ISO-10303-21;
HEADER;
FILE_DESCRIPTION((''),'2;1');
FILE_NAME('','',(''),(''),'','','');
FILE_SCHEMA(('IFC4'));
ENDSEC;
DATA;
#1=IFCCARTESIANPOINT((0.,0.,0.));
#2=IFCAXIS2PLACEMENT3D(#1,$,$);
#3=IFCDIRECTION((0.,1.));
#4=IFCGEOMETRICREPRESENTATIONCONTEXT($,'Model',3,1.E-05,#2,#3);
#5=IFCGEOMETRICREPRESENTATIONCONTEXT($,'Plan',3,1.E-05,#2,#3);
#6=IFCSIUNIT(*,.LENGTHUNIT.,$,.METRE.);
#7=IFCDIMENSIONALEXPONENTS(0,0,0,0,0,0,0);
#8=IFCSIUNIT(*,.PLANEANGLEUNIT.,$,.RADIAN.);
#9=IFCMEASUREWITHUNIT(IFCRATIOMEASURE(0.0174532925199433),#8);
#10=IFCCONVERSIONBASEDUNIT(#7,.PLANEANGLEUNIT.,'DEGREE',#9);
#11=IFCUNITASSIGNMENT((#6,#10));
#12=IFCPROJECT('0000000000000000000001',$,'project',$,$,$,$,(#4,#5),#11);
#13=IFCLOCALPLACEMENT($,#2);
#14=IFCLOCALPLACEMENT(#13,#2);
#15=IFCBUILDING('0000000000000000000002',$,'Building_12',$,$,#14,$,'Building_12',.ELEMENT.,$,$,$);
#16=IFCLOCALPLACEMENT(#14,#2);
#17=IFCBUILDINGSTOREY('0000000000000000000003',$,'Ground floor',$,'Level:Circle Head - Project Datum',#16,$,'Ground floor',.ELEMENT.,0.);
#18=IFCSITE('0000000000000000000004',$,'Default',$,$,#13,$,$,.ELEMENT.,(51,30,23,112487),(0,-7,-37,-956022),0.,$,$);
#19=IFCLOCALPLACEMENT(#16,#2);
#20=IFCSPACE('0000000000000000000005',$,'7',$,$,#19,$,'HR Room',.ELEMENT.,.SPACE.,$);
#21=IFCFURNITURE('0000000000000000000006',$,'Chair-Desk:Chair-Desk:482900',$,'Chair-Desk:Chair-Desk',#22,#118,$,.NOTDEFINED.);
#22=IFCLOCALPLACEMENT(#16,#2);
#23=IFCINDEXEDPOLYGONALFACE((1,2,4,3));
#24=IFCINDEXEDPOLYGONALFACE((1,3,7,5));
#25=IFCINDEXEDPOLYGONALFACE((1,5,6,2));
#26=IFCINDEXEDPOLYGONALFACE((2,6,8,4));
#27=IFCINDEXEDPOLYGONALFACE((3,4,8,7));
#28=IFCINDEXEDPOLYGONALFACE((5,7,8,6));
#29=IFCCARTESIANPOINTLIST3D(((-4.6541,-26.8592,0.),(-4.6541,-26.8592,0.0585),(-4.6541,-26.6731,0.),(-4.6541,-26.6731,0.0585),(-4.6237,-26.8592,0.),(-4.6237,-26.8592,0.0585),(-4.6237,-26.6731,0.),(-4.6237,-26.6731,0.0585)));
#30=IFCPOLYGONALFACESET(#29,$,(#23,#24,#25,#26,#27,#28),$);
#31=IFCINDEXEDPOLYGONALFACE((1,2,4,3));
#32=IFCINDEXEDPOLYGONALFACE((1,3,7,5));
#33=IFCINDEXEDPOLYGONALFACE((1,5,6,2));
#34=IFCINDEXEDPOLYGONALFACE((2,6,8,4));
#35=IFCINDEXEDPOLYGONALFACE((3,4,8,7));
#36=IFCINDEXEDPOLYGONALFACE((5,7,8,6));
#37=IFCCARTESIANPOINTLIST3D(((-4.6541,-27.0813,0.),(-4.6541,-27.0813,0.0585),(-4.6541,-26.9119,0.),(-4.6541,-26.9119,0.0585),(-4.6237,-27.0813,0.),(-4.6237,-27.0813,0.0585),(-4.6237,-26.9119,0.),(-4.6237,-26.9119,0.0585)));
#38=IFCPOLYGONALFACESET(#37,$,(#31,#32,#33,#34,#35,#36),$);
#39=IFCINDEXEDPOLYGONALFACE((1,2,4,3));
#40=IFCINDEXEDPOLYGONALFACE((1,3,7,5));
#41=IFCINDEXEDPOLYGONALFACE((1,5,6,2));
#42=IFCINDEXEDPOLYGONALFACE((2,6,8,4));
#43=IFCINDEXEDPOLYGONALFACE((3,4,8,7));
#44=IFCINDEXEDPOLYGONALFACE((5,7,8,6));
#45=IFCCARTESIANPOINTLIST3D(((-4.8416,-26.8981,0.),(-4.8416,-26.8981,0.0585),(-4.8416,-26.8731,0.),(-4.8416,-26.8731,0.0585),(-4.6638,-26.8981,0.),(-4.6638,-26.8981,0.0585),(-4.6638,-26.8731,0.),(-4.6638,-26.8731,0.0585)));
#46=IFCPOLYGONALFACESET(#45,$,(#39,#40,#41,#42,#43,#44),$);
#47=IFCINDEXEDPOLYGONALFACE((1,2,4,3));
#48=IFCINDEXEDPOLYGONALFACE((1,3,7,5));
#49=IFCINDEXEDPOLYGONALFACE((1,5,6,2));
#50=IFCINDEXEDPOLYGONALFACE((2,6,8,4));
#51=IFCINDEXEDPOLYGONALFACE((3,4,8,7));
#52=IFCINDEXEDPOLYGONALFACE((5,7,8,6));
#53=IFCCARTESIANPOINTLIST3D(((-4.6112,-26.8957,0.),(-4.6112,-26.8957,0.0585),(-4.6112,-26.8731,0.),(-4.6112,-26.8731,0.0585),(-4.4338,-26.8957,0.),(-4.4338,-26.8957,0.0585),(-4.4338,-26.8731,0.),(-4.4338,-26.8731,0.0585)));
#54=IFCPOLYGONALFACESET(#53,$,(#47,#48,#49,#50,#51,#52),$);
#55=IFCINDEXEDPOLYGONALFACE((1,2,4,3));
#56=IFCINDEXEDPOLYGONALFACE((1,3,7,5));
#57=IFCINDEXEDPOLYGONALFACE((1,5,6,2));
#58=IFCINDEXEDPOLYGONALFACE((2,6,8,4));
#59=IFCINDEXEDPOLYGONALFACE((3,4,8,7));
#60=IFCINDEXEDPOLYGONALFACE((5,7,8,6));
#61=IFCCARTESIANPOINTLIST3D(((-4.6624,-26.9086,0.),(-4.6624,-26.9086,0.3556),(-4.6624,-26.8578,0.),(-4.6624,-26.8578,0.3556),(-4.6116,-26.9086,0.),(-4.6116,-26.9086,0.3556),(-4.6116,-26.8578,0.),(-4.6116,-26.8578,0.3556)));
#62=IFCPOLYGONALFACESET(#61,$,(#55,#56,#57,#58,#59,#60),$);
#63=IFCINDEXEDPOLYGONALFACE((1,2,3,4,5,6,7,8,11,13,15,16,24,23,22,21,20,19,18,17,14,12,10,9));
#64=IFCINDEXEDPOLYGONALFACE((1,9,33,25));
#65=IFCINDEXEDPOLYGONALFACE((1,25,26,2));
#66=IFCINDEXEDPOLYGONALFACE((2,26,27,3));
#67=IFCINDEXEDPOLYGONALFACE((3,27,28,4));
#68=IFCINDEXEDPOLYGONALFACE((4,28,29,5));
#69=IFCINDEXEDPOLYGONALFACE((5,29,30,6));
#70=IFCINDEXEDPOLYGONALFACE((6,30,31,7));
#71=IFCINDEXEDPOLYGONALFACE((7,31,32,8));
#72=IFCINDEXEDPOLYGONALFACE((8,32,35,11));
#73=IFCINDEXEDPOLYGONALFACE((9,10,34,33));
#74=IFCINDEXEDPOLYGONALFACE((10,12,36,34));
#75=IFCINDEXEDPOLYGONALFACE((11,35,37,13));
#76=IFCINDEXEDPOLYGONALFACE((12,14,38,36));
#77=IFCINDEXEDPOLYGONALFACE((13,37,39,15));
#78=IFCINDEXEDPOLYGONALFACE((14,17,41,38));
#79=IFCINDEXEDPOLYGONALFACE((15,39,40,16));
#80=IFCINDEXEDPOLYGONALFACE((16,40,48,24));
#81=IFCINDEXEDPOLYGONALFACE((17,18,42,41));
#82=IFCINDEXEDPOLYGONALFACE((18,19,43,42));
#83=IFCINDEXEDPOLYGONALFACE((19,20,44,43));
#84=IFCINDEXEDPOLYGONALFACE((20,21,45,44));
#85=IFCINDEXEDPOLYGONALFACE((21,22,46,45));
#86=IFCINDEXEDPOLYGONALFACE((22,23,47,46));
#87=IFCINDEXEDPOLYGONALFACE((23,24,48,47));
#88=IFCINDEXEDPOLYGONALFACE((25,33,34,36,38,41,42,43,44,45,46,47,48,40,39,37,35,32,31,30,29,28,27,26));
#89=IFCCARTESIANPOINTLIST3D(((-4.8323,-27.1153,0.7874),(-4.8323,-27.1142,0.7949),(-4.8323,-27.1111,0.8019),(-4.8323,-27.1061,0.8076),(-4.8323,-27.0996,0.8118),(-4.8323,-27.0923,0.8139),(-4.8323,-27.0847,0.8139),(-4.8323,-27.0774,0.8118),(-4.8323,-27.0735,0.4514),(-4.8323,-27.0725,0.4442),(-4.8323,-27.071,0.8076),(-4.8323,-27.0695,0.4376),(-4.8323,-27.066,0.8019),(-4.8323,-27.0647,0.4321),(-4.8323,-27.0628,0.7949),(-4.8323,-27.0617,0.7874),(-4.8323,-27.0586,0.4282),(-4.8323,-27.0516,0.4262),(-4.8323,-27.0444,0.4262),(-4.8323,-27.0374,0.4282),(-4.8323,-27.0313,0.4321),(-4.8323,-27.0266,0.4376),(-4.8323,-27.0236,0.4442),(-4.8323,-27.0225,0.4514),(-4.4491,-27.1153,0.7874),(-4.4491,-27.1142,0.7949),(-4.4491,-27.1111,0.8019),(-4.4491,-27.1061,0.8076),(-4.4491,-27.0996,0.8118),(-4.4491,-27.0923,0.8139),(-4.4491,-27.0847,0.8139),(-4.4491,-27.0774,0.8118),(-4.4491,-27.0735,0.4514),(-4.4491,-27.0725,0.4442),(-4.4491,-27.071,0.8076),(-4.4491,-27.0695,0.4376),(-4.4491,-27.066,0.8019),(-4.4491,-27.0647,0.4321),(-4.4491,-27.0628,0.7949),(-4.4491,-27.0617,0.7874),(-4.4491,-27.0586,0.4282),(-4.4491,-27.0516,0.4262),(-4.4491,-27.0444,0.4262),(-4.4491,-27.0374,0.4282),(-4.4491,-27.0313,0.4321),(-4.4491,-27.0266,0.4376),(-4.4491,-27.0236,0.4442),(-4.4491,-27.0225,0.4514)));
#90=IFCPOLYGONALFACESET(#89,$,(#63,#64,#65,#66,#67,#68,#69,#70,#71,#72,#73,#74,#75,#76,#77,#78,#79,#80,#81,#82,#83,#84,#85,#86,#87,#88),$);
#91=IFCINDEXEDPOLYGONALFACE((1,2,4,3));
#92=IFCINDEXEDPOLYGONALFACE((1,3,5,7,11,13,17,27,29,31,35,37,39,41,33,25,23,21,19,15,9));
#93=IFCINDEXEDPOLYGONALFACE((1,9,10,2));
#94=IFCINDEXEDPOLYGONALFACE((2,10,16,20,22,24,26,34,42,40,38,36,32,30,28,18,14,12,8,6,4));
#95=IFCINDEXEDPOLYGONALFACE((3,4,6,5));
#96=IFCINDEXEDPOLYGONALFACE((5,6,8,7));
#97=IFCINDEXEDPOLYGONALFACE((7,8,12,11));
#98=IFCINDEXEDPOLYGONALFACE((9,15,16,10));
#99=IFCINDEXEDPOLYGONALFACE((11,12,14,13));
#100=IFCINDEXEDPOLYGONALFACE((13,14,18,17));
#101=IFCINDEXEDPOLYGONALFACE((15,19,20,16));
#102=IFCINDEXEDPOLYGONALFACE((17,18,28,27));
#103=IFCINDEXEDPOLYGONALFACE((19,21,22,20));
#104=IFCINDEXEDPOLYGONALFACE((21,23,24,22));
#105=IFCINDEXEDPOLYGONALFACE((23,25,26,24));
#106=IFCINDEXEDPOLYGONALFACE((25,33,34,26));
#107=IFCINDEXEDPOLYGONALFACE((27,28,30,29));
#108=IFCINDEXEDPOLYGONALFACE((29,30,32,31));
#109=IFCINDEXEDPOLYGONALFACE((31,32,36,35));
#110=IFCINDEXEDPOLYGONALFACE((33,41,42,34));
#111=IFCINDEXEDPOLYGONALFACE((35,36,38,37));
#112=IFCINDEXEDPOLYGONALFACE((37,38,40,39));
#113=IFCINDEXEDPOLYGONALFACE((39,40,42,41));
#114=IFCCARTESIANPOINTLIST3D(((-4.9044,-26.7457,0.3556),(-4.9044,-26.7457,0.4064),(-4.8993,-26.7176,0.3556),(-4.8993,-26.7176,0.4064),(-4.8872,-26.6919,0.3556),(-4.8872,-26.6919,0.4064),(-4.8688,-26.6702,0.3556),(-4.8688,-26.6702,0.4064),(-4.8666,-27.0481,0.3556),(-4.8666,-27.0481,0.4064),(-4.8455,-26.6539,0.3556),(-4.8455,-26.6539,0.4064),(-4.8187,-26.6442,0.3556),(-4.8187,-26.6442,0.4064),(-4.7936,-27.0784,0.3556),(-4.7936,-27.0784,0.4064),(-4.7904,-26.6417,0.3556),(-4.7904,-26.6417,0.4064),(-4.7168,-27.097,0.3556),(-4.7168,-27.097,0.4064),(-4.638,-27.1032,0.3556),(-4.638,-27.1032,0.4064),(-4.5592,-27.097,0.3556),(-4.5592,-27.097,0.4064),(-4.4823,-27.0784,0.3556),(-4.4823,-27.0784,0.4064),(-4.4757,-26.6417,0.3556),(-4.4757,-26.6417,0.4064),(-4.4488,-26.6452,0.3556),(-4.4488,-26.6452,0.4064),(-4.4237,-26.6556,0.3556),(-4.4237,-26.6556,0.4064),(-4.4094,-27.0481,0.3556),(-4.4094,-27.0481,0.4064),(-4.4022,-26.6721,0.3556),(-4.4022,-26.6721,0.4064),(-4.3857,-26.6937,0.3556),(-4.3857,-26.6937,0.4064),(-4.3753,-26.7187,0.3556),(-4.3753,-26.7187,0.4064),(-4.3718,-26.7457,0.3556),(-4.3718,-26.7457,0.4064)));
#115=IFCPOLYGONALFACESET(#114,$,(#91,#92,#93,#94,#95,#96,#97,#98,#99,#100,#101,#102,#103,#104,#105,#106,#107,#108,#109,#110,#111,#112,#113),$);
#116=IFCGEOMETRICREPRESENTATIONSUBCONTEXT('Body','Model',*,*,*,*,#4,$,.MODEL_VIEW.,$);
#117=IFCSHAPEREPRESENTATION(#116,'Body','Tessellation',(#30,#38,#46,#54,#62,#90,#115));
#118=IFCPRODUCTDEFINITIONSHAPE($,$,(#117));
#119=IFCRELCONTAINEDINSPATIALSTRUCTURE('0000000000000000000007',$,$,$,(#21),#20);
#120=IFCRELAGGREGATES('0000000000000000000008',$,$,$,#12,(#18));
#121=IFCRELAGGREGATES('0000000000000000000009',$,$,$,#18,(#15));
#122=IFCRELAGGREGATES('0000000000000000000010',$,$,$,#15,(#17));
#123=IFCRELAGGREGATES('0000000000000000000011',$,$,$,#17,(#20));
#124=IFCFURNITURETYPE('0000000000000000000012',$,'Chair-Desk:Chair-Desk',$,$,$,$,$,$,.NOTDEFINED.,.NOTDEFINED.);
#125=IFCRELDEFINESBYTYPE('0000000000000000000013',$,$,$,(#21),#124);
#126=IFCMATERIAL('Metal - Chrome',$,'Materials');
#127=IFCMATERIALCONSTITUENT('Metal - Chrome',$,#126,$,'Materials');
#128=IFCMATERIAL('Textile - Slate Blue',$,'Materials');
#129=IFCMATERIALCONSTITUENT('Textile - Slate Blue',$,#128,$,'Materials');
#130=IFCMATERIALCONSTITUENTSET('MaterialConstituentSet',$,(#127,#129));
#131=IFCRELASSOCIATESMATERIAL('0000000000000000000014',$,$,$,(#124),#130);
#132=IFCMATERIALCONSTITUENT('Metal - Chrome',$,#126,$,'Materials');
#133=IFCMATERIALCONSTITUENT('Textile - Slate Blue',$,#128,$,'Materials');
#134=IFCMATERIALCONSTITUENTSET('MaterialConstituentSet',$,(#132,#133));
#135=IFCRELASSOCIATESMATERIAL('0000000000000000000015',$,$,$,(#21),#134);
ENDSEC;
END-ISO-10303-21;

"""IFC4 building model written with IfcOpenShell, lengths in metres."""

from ifc_helpers import new_model, entity, si_unit, converted_unit, direction, frame, origin, place, context, subcontext, project, spatial, line, arc, indexed_curve, outline, extrude, source, transform, mapped, material, constituent, constituent_set, type_object, type_shapes, element, save


model = new_model("IFC4")

# Units and contexts
model_context = context("Model", 3, precision=1e-05, world=origin(), true_north=direction((0.0, 1.0)))
plan_context = context("Plan", 3, precision=1e-05, world=origin(), true_north=direction((0.0, 1.0)))
body_context = subcontext(model_context, "Body", "Model", "MODEL_VIEW")
ifc_project = project(units=[si_unit("LENGTHUNIT", "METRE"), converted_unit("PLANEANGLEUNIT", "DEGREE", entity("IfcRatioMeasure", 0.0174532925199433), si_unit("PLANEANGLEUNIT", "RADIAN"), dimensions=[0, 0, 0, 0, 0, 0, 0])], contexts=[model_context, plan_context])

# Site, building, storey
site_placement = place(None, origin())
site = spatial("IfcSite", under=ifc_project, at=site_placement, Name="Default", CompositionType="ELEMENT", RefLatitude=(51, 30, 23, 112487), RefLongitude=(0, -7, -37, -956022), RefElevation=0.0)
building_placement = place(site_placement, origin())
building = spatial("IfcBuilding", under=site, at=building_placement, Name="Building_12", LongName="Building_12", CompositionType="ELEMENT")
storey_placement = place(building_placement, origin())
storey = spatial("IfcBuildingStorey", under=building, at=storey_placement, Name="Ground floor", ObjectType="Level:Circle Head - Project Datum", LongName="Ground floor", CompositionType="ELEMENT", Elevation=0.0)

# Shared definitions
space_placement = place(storey_placement, origin())
space = spatial("IfcSpace", under=storey, at=space_placement, Name="7", LongName="HR Room", CompositionType="ELEMENT", PredefinedType="SPACE")

# Furniture
ifc_material_1 = material(Name="Metal - Chrome", Category="Materials")
ifc_material_2 = material(Name="Textile - Slate Blue", Category="Materials")
ifc_constituent_1 = constituent(ifc_material_1, Name="Metal - Chrome", Category="Materials")
ifc_constituent_2 = constituent(ifc_material_2, Name="Textile - Slate Blue", Category="Materials")
ifc_constituent_set_1 = constituent_set(constituents=[ifc_constituent_1, ifc_constituent_2], Name="MaterialConstituentSet")
furniture_type = type_object("IfcFurnitureType", Name="Chair-Desk:Chair-Desk", AssemblyPlace="NOTDEFINED", PredefinedType="NOTDEFINED", material=ifc_constituent_set_1)
shared_shape_1 = source(origin(), body_context, "Body", "SweptSolid", [
    extrude(outline(indexed_curve([(-0.0152, -0.093), (0.0152, -0.093), (0.0152, 0.093), (-0.0152, 0.093), (-0.0152, -0.093)], self_intersect=False)), frame((-0.0009, 0.2819, 0.0)), (0.0, 0.0, 1.0), 0.0585),
    extrude(outline(indexed_curve([(-0.0152, -0.0847), (0.0152, -0.0847), (0.0152, 0.0847), (-0.0152, 0.0847), (-0.0152, -0.0847)], self_intersect=False)), frame((-0.0009, 0.0515, 0.0), z_axis=(0.0, 0.0, 1.0), x_axis=(-1.0, 0.0, 0.0)), (0.0, 0.0, 1.0), 0.0585),
    extrude(outline(indexed_curve([(-0.0125, -0.0889), (0.0125, -0.0889), (0.0125, 0.0889), (-0.0125, 0.0889), (-0.0125, -0.0889)], self_intersect=False)), frame((-0.1148, 0.1625, 0.0), z_axis=(0.0, 0.0, 1.0), x_axis=(0.0, -1.0, 0.0)), (0.0, 0.0, 1.0), 0.0585),
    extrude(outline(indexed_curve([(-0.0887, -0.0113), (0.0887, -0.0113), (0.0887, 0.0113), (-0.0887, 0.0113), (-0.0887, -0.0113)], self_intersect=False)), frame((0.1155, 0.1637, 0.0), z_axis=(0.0, 0.0, 1.0), x_axis=(-1.0, 0.0, 0.0)), (0.0, 0.0, 1.0), 0.0585),
    extrude(outline(indexed_curve([(-0.0254, -0.0254), (0.0254, -0.0254), (0.0254, 0.0254), (-0.0254, 0.0254), (-0.0254, -0.0254)], self_intersect=False)), frame((0.0009, 0.1649, 0.0), z_axis=(0.0, 0.0, 1.0), x_axis=(-1.0, 0.0, 0.0)), (0.0, 0.0, 1.0), 0.3556),
    extrude(outline(indexed_curve([(0.0065, 0.168), (-0.0202, 0.1948), (-0.047, 0.168), (-0.0052, -0.168), (0.0202, -0.1935), (0.0457, -0.168)], segments=[arc(1, 2, 3), line(3, 4), arc(4, 5, 6), line(6, 1)], self_intersect=False)), frame((-0.1944, -0.0202, 0.6194), z_axis=(1.0, 0.0, 0.0), x_axis=(0.0, 1.0, 0.0)), (0.0, 0.0, 1.0), 0.3833),
    extrude(outline(indexed_curve([(-0.0989, -0.2577), (0.2059, -0.2577), (0.2889, -0.0377), (0.2626, 0.1959), (-0.0328, 0.2708), (-0.1095, 0.2497), (-0.1489, 0.1805), (-0.1879, -0.1317), (-0.1694, -0.2131)], segments=[line(1, 2), arc(2, 3, 4), line(4, 5), arc(5, 6, 7), line(7, 8), arc(8, 9, 1)], self_intersect=False)), frame((0.0016, 0.2363, 0.3556), z_axis=(0.0, 0.0, 1.0), x_axis=(0.124035, -0.992278, 0.0)), (0.0, 0.0, 1.0), 0.0508),
])
type_shapes(furniture_type, [shared_shape_1])
ifc_constituent_3 = constituent(ifc_material_1, Name="Metal - Chrome", Category="Materials")
ifc_constituent_4 = constituent(ifc_material_2, Name="Textile - Slate Blue", Category="Materials")
ifc_constituent_set_2 = constituent_set(constituents=[ifc_constituent_3, ifc_constituent_4], Name="MaterialConstituentSet")
furniture_1_placement = place(space_placement, frame((-4.638, -27.0481, 0.0)))
element("IfcFurniture", 1, at=furniture_1_placement, inside=space, type_object=furniture_type, material=ifc_constituent_set_2, Name="Chair-Desk:Chair-Desk:482900", ObjectType="Chair-Desk:Chair-Desk", PredefinedType="NOTDEFINED", context=body_context, shape_type="MappedRepresentation", body=[
    mapped(shared_shape_1, transform((0.0, 0.0, 0.0), scale=1.0)),
])

save(model, "model.ifc")
